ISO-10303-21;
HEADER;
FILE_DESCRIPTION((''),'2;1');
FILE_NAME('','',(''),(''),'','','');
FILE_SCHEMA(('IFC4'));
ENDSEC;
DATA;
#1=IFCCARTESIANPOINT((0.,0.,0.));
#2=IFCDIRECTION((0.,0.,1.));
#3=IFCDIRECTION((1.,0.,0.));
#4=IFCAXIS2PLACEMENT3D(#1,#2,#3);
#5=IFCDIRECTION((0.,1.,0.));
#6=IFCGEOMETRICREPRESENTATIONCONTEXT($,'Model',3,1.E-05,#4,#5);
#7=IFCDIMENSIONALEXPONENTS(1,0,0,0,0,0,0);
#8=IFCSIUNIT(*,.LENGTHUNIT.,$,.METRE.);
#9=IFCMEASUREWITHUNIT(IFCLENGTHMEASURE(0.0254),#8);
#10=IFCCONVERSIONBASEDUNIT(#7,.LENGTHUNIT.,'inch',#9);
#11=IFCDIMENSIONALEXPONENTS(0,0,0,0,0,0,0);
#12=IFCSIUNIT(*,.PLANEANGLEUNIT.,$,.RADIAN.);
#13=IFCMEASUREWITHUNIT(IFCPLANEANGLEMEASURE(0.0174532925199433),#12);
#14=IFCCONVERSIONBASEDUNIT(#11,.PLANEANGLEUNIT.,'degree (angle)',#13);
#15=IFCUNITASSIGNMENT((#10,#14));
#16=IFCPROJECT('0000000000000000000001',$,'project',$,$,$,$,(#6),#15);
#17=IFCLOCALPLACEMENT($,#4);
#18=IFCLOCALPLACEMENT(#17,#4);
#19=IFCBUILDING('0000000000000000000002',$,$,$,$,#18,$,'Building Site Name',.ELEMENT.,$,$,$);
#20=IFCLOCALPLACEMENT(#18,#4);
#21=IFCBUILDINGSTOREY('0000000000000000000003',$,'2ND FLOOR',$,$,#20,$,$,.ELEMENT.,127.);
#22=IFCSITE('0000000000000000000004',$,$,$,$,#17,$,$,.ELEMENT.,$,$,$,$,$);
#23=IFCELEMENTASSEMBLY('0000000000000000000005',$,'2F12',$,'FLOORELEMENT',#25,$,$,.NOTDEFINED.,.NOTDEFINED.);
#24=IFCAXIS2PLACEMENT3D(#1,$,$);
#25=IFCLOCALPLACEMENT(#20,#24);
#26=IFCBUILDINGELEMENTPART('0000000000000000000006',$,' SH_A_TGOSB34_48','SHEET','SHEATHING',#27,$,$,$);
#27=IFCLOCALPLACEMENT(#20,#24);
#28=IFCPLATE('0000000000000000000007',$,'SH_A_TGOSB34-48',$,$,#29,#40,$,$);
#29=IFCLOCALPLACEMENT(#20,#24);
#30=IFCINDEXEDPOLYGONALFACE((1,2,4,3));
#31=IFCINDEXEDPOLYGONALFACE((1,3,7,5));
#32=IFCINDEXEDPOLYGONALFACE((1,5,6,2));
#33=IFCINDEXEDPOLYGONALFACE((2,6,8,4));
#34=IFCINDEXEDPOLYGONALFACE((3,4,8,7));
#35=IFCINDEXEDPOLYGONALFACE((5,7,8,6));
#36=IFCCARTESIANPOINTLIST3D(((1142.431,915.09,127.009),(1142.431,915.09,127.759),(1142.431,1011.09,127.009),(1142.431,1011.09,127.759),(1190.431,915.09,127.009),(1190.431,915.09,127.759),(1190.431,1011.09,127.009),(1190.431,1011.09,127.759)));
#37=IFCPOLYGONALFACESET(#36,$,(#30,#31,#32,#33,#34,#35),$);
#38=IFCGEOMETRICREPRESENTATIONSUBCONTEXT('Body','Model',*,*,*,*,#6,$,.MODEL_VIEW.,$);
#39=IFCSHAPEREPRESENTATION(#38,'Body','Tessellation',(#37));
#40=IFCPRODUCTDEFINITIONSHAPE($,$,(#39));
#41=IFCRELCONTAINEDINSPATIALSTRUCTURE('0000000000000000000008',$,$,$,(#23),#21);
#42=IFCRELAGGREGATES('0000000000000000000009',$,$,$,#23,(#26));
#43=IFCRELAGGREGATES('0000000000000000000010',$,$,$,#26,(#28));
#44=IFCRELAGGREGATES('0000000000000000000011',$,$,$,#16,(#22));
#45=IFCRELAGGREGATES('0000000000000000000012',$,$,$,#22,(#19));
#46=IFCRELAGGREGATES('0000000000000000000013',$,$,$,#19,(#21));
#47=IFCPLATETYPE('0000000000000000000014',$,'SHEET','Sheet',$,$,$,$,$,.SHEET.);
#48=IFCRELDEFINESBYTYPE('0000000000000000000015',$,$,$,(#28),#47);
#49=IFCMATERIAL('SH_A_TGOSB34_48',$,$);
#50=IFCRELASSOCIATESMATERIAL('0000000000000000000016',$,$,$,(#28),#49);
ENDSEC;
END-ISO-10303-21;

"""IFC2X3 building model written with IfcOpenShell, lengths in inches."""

from ifc_helpers import new_model, entity, si_unit, converted_unit, direction, frame, frame_2d, origin_with_axes, place, context, subcontext, project, spatial, rectangle, extrude, material, type_object, element, aggregate, save


model = new_model("IFC2X3")

# Units and contexts
model_context = context("Model", 3, precision=1e-05, world=origin_with_axes(), true_north=direction((0.0, 1.0, 0.0)))
body_context = subcontext(model_context, "Body", "Model", "MODEL_VIEW")
ifc_project = project(units=[converted_unit("LENGTHUNIT", "inch", entity("IfcLengthMeasure", 0.0254), si_unit("LENGTHUNIT", "METRE"), dimensions=[1, 0, 0, 0, 0, 0, 0]), converted_unit("PLANEANGLEUNIT", "degree (angle)", entity("IfcPlaneAngleMeasure", 0.0174532925199433), si_unit("PLANEANGLEUNIT", "RADIAN"), dimensions=[0, 0, 0, 0, 0, 0, 0])], contexts=[model_context])

# Site, building, storey
site_placement = place(None, origin_with_axes())
site = spatial("IfcSite", under=ifc_project, at=site_placement, CompositionType="ELEMENT")
building_placement = place(site_placement, origin_with_axes())
building = spatial("IfcBuilding", under=site, at=building_placement, LongName="Building Site Name", CompositionType="ELEMENT")
storey_placement = place(building_placement, origin_with_axes())
storey = spatial("IfcBuildingStorey", under=building, at=storey_placement, Name="2ND FLOOR", CompositionType="ELEMENT", Elevation=127.0)

# Element assembly
assembly_1_placement = place(storey_placement, origin_with_axes())
assembly_1 = element("IfcElementAssembly", 1, at=assembly_1_placement, inside=storey, Name="2F12", ObjectType="FLOORELEMENT", AssemblyPlace="NOTDEFINED", PredefinedType="NOTDEFINED")

# Building element part
building_element_part_1 = element("IfcBuildingElementPart", 2, Name=" SH_A_TGOSB34_48", Description="SHEET", ObjectType="SHEATHING")
aggregate(assembly_1, [building_element_part_1])

# Plate
ifc_material_1 = material(Name="SH_A_TGOSB34_48")
plate_type = type_object("IfcPlateType", Name="SHEET", Description="Sheet", PredefinedType="SHEET")
plate_1_placement = place(assembly_1_placement, frame((1166.431, 963.09, 127.759), z_axis=(0.0, 0.0, 1.0), x_axis=(1.0, 0.0, 0.0)))
plate_1 = element("IfcPlate", 3, at=plate_1_placement, type_object=plate_type, material=ifc_material_1, Name="SH_A_TGOSB34-48", context=body_context, shape_type="SweptSolid", body=[
    extrude(rectangle(XDim=0.75, YDim=48.0, at=frame_2d((0.0, -0.375), x_axis=(0.0, -1.0))), frame((0.0, -48.0, 0.0), z_axis=(0.0, 1.0, 0.0), x_axis=(-1.0, 0.0, 0.0)), (0.0, 0.0, 1.0), 96.0),
])
aggregate(building_element_part_1, [plate_1])

save(model, "model.ifc")
